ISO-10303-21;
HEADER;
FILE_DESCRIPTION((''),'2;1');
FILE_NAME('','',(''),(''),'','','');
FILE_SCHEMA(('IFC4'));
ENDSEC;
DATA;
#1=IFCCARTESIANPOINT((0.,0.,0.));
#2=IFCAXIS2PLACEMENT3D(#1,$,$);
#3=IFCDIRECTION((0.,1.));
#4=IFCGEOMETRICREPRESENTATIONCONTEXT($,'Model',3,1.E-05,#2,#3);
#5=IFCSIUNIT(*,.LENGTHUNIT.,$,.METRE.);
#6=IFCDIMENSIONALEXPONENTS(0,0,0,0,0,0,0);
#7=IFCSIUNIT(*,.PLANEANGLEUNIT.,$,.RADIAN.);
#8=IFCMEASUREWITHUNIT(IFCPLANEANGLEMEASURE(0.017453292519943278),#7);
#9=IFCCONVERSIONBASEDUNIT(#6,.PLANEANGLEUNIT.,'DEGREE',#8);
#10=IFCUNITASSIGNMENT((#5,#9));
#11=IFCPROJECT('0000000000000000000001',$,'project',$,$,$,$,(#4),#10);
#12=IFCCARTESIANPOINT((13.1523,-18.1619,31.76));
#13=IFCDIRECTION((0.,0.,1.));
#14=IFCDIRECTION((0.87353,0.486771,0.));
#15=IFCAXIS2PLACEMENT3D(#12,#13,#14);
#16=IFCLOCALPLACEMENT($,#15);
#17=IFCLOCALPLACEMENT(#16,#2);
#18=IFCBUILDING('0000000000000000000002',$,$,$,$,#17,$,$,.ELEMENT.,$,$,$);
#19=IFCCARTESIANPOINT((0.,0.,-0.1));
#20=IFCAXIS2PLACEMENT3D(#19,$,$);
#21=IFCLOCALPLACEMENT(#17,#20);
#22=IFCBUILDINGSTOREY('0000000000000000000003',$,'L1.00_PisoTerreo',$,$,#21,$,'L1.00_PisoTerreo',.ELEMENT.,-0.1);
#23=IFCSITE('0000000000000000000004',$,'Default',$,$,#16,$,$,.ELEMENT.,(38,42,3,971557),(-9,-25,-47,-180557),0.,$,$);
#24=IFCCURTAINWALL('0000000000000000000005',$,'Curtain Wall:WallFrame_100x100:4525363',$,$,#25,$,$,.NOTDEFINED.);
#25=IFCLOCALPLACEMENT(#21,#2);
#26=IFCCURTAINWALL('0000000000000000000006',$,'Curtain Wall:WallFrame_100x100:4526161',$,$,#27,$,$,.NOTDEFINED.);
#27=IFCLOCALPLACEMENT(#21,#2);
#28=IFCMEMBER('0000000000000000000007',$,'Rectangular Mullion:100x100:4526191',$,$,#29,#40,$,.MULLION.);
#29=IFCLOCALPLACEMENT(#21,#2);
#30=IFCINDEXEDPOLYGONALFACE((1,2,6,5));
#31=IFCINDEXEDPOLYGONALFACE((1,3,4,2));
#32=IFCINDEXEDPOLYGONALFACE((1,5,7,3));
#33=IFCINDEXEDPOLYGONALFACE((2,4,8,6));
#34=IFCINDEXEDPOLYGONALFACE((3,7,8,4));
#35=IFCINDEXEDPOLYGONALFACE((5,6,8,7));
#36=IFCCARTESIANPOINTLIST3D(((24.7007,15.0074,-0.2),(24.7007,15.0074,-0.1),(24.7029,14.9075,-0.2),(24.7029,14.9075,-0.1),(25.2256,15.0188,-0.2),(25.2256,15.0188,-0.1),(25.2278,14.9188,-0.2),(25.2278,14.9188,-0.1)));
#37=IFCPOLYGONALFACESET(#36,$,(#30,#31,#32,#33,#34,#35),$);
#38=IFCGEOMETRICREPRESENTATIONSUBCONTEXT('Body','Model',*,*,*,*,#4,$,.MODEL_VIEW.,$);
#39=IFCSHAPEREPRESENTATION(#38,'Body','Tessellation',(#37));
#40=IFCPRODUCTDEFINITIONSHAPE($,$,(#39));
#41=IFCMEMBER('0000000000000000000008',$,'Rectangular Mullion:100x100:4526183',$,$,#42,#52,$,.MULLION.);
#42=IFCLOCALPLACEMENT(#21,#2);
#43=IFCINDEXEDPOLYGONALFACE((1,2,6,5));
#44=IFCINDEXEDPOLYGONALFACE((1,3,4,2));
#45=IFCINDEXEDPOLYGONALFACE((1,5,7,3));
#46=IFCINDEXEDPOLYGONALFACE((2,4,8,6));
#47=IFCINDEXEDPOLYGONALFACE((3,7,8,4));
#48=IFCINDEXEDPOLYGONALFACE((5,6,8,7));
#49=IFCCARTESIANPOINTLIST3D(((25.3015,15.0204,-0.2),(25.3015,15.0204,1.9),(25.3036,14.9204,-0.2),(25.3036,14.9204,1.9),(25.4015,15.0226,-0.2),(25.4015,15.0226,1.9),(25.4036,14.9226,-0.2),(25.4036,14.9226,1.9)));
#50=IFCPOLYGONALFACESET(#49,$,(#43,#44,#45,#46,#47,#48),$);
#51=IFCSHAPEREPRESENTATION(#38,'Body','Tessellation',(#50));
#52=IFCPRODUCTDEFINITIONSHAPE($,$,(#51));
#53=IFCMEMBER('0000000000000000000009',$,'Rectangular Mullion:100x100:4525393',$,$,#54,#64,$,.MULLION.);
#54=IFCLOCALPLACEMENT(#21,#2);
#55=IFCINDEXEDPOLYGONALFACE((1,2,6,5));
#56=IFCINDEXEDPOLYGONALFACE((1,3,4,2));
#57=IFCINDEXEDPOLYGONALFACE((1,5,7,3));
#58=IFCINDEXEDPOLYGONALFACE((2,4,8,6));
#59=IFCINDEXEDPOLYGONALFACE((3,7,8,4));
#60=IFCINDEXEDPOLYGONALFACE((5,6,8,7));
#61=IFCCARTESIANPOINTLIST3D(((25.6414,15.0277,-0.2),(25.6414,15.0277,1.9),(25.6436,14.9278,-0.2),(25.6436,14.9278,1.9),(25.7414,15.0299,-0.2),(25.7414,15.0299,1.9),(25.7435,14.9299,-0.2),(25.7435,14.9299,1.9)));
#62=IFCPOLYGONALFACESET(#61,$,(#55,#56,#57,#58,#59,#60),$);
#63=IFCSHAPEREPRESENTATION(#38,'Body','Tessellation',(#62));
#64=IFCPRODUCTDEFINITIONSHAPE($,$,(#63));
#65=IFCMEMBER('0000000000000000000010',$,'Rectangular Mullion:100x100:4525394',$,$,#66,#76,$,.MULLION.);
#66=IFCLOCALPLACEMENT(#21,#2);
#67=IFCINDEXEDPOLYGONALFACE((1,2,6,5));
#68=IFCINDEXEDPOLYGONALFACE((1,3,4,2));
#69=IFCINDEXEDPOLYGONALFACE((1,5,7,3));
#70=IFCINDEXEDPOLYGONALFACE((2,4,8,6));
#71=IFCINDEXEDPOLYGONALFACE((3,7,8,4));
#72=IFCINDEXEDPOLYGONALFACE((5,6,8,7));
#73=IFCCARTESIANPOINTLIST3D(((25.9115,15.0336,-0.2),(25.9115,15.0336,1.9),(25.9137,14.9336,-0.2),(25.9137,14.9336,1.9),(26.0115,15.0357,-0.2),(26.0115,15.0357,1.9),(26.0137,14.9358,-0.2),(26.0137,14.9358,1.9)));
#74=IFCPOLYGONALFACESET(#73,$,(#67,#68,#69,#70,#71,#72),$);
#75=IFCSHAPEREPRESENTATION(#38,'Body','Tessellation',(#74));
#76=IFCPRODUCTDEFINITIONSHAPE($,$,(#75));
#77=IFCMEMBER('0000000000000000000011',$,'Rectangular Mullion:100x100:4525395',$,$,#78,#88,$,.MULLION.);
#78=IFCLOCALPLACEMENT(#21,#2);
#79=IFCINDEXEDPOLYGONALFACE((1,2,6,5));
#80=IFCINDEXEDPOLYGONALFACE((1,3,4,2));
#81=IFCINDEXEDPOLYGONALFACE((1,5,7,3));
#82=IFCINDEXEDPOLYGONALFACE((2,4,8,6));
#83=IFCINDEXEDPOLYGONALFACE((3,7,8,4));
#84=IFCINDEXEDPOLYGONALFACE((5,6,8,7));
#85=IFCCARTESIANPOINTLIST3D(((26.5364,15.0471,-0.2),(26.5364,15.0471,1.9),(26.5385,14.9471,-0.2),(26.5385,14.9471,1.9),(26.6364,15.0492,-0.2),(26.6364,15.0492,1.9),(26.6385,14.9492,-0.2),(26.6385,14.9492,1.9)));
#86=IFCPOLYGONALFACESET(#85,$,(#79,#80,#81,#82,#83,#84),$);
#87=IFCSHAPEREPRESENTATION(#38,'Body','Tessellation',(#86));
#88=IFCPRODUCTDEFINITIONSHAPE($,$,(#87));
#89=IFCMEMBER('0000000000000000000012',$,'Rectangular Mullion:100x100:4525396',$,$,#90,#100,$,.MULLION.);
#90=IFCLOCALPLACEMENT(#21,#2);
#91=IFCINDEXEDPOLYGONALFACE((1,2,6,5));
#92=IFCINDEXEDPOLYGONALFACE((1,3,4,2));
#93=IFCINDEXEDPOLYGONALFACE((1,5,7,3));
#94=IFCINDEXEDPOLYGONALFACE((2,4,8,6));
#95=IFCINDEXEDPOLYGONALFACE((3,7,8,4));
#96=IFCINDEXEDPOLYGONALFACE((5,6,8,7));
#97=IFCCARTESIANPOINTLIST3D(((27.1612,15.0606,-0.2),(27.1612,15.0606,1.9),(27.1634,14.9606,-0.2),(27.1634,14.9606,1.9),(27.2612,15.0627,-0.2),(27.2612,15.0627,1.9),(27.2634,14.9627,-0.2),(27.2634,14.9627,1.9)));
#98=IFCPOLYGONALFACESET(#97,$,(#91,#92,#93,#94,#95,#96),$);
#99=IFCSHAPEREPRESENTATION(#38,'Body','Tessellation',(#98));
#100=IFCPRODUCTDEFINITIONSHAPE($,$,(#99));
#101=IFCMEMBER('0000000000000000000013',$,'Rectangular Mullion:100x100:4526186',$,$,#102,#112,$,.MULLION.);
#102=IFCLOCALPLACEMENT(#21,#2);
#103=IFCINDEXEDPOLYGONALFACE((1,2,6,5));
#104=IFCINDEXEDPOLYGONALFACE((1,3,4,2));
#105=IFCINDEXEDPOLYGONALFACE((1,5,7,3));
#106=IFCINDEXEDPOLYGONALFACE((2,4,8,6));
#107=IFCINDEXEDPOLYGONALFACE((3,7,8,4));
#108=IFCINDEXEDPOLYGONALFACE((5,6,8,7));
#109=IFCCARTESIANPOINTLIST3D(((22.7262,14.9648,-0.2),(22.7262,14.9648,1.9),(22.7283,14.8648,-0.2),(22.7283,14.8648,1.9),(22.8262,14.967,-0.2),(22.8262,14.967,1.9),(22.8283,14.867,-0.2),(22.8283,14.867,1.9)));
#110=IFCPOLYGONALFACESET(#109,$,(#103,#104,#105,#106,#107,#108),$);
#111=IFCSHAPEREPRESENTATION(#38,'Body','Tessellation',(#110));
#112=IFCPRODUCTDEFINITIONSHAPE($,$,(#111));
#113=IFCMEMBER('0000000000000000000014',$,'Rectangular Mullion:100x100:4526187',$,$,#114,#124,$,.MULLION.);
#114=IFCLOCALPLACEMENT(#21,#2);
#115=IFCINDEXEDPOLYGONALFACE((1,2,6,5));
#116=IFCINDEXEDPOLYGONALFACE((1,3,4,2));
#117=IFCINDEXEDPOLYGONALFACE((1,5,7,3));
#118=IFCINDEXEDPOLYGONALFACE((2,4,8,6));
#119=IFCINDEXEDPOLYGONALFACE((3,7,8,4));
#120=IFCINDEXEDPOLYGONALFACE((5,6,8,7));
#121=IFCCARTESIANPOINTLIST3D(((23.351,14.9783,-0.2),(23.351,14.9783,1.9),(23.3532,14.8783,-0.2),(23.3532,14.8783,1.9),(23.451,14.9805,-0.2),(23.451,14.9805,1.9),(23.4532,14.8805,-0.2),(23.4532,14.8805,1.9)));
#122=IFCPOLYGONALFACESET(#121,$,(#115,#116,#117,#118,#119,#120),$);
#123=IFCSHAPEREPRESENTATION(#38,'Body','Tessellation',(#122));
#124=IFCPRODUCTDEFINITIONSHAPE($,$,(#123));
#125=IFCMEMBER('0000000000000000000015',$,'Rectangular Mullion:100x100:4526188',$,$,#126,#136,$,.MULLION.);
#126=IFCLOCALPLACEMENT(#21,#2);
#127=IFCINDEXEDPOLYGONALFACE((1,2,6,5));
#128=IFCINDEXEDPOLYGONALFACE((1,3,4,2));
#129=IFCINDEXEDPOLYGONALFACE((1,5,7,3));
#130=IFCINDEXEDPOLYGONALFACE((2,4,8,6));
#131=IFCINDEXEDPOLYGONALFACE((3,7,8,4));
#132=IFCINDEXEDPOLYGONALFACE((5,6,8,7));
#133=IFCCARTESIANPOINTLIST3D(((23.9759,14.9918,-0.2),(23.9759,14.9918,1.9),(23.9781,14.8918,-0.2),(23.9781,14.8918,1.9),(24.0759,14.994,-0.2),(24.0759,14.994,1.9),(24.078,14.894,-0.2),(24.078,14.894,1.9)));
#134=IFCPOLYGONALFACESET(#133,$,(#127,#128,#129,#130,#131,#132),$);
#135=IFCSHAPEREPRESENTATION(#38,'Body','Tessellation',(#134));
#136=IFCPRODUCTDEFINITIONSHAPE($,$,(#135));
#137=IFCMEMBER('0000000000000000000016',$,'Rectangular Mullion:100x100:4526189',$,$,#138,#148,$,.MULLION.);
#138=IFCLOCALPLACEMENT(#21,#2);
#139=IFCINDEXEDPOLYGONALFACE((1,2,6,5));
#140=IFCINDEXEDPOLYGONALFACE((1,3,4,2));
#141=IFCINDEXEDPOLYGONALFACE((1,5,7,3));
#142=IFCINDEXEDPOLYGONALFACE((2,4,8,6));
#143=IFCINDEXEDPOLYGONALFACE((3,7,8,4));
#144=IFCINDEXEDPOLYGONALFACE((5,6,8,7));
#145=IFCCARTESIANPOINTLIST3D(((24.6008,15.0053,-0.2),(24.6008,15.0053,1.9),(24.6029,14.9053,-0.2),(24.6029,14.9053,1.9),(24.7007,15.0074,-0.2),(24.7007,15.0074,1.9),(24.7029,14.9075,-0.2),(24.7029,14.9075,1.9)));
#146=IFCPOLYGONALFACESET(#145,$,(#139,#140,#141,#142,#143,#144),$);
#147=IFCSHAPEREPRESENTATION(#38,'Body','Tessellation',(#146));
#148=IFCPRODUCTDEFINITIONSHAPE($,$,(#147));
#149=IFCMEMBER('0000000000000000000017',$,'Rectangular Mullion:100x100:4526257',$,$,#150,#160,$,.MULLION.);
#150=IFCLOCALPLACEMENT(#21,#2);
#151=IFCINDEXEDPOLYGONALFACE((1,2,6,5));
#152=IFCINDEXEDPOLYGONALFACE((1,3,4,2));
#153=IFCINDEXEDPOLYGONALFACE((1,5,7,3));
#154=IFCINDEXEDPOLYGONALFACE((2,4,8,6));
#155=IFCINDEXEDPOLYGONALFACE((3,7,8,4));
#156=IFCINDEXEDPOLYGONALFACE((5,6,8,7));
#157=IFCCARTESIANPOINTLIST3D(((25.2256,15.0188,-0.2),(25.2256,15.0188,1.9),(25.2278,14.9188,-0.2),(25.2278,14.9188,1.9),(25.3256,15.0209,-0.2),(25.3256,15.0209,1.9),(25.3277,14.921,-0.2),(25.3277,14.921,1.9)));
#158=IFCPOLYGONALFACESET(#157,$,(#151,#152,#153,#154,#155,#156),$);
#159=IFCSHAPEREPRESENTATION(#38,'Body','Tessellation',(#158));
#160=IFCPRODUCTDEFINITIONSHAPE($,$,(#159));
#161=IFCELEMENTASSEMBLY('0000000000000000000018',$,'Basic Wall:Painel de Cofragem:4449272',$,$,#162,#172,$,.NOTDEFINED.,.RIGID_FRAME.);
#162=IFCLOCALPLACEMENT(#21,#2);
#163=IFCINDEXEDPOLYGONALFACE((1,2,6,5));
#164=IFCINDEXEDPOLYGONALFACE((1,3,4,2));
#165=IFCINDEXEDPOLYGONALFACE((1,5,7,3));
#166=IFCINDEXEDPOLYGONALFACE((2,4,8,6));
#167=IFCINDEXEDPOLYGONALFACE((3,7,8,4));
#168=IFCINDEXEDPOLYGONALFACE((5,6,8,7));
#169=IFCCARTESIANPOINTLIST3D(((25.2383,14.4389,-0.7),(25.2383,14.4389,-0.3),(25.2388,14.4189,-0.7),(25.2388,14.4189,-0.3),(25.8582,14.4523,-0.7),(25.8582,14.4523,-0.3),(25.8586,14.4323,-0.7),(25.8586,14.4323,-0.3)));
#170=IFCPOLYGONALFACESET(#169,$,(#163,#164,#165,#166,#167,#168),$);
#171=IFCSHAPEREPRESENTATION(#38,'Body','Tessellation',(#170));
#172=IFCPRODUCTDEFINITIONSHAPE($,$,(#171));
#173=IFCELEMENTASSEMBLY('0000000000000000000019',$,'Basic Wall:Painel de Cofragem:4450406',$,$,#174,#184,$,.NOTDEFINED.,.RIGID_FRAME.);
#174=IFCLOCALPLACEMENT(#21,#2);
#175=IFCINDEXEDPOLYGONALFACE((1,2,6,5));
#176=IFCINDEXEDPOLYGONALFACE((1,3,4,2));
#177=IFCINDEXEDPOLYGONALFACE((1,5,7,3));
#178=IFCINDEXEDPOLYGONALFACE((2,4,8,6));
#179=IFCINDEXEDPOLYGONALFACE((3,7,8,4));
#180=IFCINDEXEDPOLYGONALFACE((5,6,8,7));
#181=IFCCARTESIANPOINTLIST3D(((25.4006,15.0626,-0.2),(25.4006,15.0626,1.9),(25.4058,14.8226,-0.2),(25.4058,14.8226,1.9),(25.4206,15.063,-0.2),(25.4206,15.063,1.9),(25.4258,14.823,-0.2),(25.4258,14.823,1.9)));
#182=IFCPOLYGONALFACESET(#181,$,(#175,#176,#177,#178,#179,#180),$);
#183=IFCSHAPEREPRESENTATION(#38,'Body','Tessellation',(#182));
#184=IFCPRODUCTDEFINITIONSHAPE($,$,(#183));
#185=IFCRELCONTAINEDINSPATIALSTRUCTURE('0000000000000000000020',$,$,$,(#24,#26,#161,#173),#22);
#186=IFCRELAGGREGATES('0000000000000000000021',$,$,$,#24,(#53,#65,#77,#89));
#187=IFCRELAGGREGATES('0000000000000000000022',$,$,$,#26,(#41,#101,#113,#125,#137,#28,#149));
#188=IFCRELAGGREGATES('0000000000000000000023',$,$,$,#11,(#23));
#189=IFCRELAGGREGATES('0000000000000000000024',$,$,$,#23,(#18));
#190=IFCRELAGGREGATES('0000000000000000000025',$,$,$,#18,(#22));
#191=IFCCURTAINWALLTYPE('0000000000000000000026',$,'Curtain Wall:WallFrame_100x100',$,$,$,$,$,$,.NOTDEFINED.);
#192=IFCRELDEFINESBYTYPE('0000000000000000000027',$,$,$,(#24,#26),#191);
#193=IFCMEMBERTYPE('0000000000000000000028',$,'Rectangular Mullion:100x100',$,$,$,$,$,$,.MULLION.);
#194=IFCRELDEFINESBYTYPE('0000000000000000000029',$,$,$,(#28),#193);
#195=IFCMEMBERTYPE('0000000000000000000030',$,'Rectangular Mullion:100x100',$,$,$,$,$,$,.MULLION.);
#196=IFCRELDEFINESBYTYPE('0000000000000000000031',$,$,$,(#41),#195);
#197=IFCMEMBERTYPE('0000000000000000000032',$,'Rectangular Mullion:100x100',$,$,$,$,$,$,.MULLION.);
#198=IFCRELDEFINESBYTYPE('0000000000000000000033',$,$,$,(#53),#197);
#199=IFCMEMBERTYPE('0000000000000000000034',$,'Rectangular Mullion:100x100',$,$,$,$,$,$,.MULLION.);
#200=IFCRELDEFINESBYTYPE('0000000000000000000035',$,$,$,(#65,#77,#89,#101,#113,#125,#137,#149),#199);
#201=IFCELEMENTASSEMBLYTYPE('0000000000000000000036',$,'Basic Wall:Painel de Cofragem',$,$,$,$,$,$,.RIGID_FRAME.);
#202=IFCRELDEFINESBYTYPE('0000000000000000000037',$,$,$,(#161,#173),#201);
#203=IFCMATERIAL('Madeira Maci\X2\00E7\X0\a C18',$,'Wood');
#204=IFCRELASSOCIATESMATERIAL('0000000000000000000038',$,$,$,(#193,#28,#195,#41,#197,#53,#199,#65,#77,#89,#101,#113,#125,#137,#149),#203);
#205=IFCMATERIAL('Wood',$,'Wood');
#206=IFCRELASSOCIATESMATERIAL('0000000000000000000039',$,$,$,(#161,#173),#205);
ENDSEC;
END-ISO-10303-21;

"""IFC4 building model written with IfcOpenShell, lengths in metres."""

from ifc_helpers import new_model, entity, si_unit, converted_unit, direction, frame, origin, place, context, subcontext, project, spatial, indexed_curve, outline, extrude, source, transform, mapped, material, type_object, type_shapes, element, aggregate, save


model = new_model("IFC4")

# Units and contexts
model_context = context("Model", 3, precision=1e-05, world=origin(), true_north=direction((0.0, 1.0)))
body_context = subcontext(model_context, "Body", "Model", "MODEL_VIEW")
ifc_project = project(units=[si_unit("LENGTHUNIT", "METRE"), converted_unit("PLANEANGLEUNIT", "DEGREE", entity("IfcPlaneAngleMeasure", 0.017453292519943278), si_unit("PLANEANGLEUNIT", "RADIAN"), dimensions=[0, 0, 0, 0, 0, 0, 0])], contexts=[model_context])

# Site, building, storey
site_placement = place(None, frame((13.1523, -18.1619, 31.76), z_axis=(0.0, 0.0, 1.0), x_axis=(0.87353, 0.486771, 0.0)))
site = spatial("IfcSite", under=ifc_project, at=site_placement, Name="Default", CompositionType="ELEMENT", RefLatitude=(38, 42, 3, 971557), RefLongitude=(-9, -25, -47, -180557), RefElevation=0.0)
building_placement = place(site_placement, origin())
building = spatial("IfcBuilding", under=site, at=building_placement, CompositionType="ELEMENT")
storey_placement = place(building_placement, frame((0.0, 0.0, -0.1)))
storey = spatial("IfcBuildingStorey", under=building, at=storey_placement, Name="L1.00_PisoTerreo", LongName="L1.00_PisoTerreo", CompositionType="ELEMENT", Elevation=-0.1)

# Curtain walls
curtain_wall_type = type_object("IfcCurtainWallType", Name="Curtain Wall:WallFrame_100x100", PredefinedType="NOTDEFINED")
curtain_wall_1_placement = place(storey_placement, frame((0.0, 0.0, 0.1)))
curtain_wall_1 = element("IfcCurtainWall", 1, at=curtain_wall_1_placement, inside=storey, type_object=curtain_wall_type, Name="Curtain Wall:WallFrame_100x100:4525363", PredefinedType="NOTDEFINED")
ifc_material_1 = material(Name="Madeira Maciça C18", Category="Wood")
curtain_wall_2_placement = place(storey_placement, frame((0.0, 0.0, 0.1)))
curtain_wall_2 = element("IfcCurtainWall", 2, at=curtain_wall_2_placement, inside=storey, type_object=curtain_wall_type, Name="Curtain Wall:WallFrame_100x100:4526161", PredefinedType="NOTDEFINED")

# Members
member_type_1 = type_object("IfcMemberType", Name="Rectangular Mullion:100x100", PredefinedType="MULLION", material=ifc_material_1)
shared_shape_1 = source(origin(), body_context, "Body", "SweptSolid", [
    extrude(outline(indexed_curve([(-0.05, -0.05), (0.05, -0.05), (0.05, 0.05), (-0.05, 0.05), (-0.05, -0.05)], self_intersect=False)), frame((-0.05, 0.0, -0.525), z_axis=(0.0, 0.0, 1.0), x_axis=(0.0, -1.0, 0.0)), (0.0, 0.0, 1.0), 0.525),
])
type_shapes(member_type_1, [shared_shape_1])
member_1_placement = place(curtain_wall_2_placement, frame((24.7018, 14.9575, -0.3), z_axis=(-0.999767, -0.021581, 0.0), x_axis=(0.0, 0.0, -1.0)))
member_1 = element("IfcMember", 3, at=member_1_placement, type_object=member_type_1, material=ifc_material_1, Name="Rectangular Mullion:100x100:4526191", PredefinedType="MULLION", context=body_context, shape_type="MappedRepresentation", body=[
    mapped(shared_shape_1, transform((0.0, 0.0, 0.0), scale=1.0)),
])
member_type_2 = type_object("IfcMemberType", Name="Rectangular Mullion:100x100", PredefinedType="MULLION", material=ifc_material_1)
shared_shape_2 = source(origin(), body_context, "Body", "SweptSolid", [
    extrude(outline(indexed_curve([(-0.05, -0.05), (0.05, -0.05), (0.05, 0.05), (-0.05, 0.05), (-0.05, -0.05)], self_intersect=False)), frame((-0.05, 0.0, -2.1), z_axis=(0.0, 0.0, 1.0), x_axis=(-1.0, 0.0, 0.0)), (0.0, 0.0, 1.0), 2.1),
])
type_shapes(member_type_2, [shared_shape_2])
member_2_placement = place(curtain_wall_2_placement, frame((25.4025, 14.9726, -0.3), z_axis=(0.0, 0.0, -1.0), x_axis=(0.999767, 0.021581, 0.0)))
member_2 = element("IfcMember", 4, at=member_2_placement, type_object=member_type_2, material=ifc_material_1, Name="Rectangular Mullion:100x100:4526183", PredefinedType="MULLION", context=body_context, shape_type="MappedRepresentation", body=[
    mapped(shared_shape_2, transform((0.0, 0.0, 0.0), scale=1.0)),
])
member_type_3 = type_object("IfcMemberType", Name="Rectangular Mullion:100x100", PredefinedType="MULLION", material=ifc_material_1)
shared_shape_3 = source(origin(), body_context, "Body", "SweptSolid", [
    extrude(outline(indexed_curve([(-0.05, -0.05), (0.05, -0.05), (0.05, 0.05), (-0.05, 0.05), (-0.05, -0.05)], self_intersect=False)), frame((-0.05, 0.0, -2.1), z_axis=(0.0, 0.0, 1.0), x_axis=(0.0, -1.0, 0.0)), (0.0, 0.0, 1.0), 2.1),
])
type_shapes(member_type_3, [shared_shape_3])
member_3_placement = place(curtain_wall_1_placement, frame((25.6425, 14.9778, 1.8), z_axis=(0.0, 0.0, 1.0), x_axis=(-0.999767, -0.021581, 0.0)))
member_3 = element("IfcMember", 5, at=member_3_placement, type_object=member_type_3, material=ifc_material_1, Name="Rectangular Mullion:100x100:4525393", PredefinedType="MULLION", context=body_context, shape_type="MappedRepresentation", body=[
    mapped(shared_shape_3, transform((0.0, 0.0, 0.0), scale=1.0)),
])
member_type_4 = type_object("IfcMemberType", Name="Rectangular Mullion:100x100", PredefinedType="MULLION", material=ifc_material_1)
shared_shape_4 = source(origin(), body_context, "Body", "SweptSolid", [
    extrude(outline(indexed_curve([(-0.05, -0.05), (0.05, -0.05), (0.05, 0.05), (-0.05, 0.05), (-0.05, -0.05)], self_intersect=False)), frame((0.0, 0.0, -2.1), z_axis=(0.0, 0.0, 1.0), x_axis=(-1.0, 0.0, 0.0)), (0.0, 0.0, 1.0), 2.1),
])
type_shapes(member_type_4, [shared_shape_4])
member_4_placement = place(curtain_wall_1_placement, frame((25.9626, 14.9847, -0.3), z_axis=(0.0, 0.0, -1.0), x_axis=(0.999767, 0.021581, 0.0)))
member_4 = element("IfcMember", 6, at=member_4_placement, type_object=member_type_4, material=ifc_material_1, Name="Rectangular Mullion:100x100:4525394", PredefinedType="MULLION", context=body_context, shape_type="MappedRepresentation", body=[
    mapped(shared_shape_4, transform((0.0, 0.0, 0.0), scale=1.0)),
])
member_5_placement = place(curtain_wall_1_placement, frame((26.5874, 14.9982, -0.3), z_axis=(0.0, 0.0, -1.0), x_axis=(0.999767, 0.021581, 0.0)))
member_5 = element("IfcMember", 7, at=member_5_placement, type_object=member_type_4, material=ifc_material_1, Name="Rectangular Mullion:100x100:4525395", PredefinedType="MULLION", context=body_context, shape_type="MappedRepresentation", body=[
    mapped(shared_shape_4, transform((0.0, 0.0, 0.0), scale=1.0)),
])
member_6_placement = place(curtain_wall_1_placement, frame((27.2123, 15.0116, -0.3), z_axis=(0.0, 0.0, -1.0), x_axis=(0.999767, 0.021581, 0.0)))
member_6 = element("IfcMember", 8, at=member_6_placement, type_object=member_type_4, material=ifc_material_1, Name="Rectangular Mullion:100x100:4525396", PredefinedType="MULLION", context=body_context, shape_type="MappedRepresentation", body=[
    mapped(shared_shape_4, transform((0.0, 0.0, 0.0), scale=1.0)),
])
aggregate(curtain_wall_1, [member_3, member_4, member_5, member_6])
member_7_placement = place(curtain_wall_2_placement, frame((22.7773, 14.9159, -0.3), z_axis=(0.0, 0.0, -1.0), x_axis=(0.999767, 0.021581, 0.0)))
member_7 = element("IfcMember", 9, at=member_7_placement, type_object=member_type_4, material=ifc_material_1, Name="Rectangular Mullion:100x100:4526186", PredefinedType="MULLION", context=body_context, shape_type="MappedRepresentation", body=[
    mapped(shared_shape_4, transform((0.0, 0.0, 0.0), scale=1.0)),
])
member_8_placement = place(curtain_wall_2_placement, frame((23.4021, 14.9294, -0.3), z_axis=(0.0, 0.0, -1.0), x_axis=(0.999767, 0.021581, 0.0)))
member_8 = element("IfcMember", 10, at=member_8_placement, type_object=member_type_4, material=ifc_material_1, Name="Rectangular Mullion:100x100:4526187", PredefinedType="MULLION", context=body_context, shape_type="MappedRepresentation", body=[
    mapped(shared_shape_4, transform((0.0, 0.0, 0.0), scale=1.0)),
])
member_9_placement = place(curtain_wall_2_placement, frame((24.027, 14.9429, -0.3), z_axis=(0.0, 0.0, -1.0), x_axis=(0.999767, 0.021581, 0.0)))
member_9 = element("IfcMember", 11, at=member_9_placement, type_object=member_type_4, material=ifc_material_1, Name="Rectangular Mullion:100x100:4526188", PredefinedType="MULLION", context=body_context, shape_type="MappedRepresentation", body=[
    mapped(shared_shape_4, transform((0.0, 0.0, 0.0), scale=1.0)),
])
member_10_placement = place(curtain_wall_2_placement, frame((24.6518, 14.9564, -0.3), z_axis=(0.0, 0.0, -1.0), x_axis=(0.999767, 0.021581, 0.0)))
member_10 = element("IfcMember", 12, at=member_10_placement, type_object=member_type_4, material=ifc_material_1, Name="Rectangular Mullion:100x100:4526189", PredefinedType="MULLION", context=body_context, shape_type="MappedRepresentation", body=[
    mapped(shared_shape_4, transform((0.0, 0.0, 0.0), scale=1.0)),
])
member_11_placement = place(curtain_wall_2_placement, frame((25.2767, 14.9699, -0.3), z_axis=(0.0, 0.0, -1.0), x_axis=(0.999767, 0.021581, 0.0)))
member_11 = element("IfcMember", 13, at=member_11_placement, type_object=member_type_4, material=ifc_material_1, Name="Rectangular Mullion:100x100:4526257", PredefinedType="MULLION", context=body_context, shape_type="MappedRepresentation", body=[
    mapped(shared_shape_4, transform((0.0, 0.0, 0.0), scale=1.0)),
])
aggregate(curtain_wall_2, [member_2, member_7, member_8, member_9, member_10, member_1, member_11])

# Element assemblies
ifc_material_2 = material(Name="Wood", Category="Wood")
element_assembly_type = type_object("IfcElementAssemblyType", Name="Basic Wall:Painel de Cofragem", PredefinedType="RIGID_FRAME")
assembly_1_placement = place(storey_placement, frame((25.2385, 14.4289, -0.7), z_axis=(0.0, 0.0, 1.0), x_axis=(0.999767, 0.021581, 0.0)))
element("IfcElementAssembly", 14, at=assembly_1_placement, inside=storey, type_object=element_assembly_type, material=ifc_material_2, Name="Basic Wall:Painel de Cofragem:4449272", AssemblyPlace="NOTDEFINED", PredefinedType="RIGID_FRAME", context=body_context, shape_type="SweptSolid", body=[
    extrude(outline(indexed_curve([(0.62, 0.01), (0.0, 0.01), (0.0, -0.01), (0.62, -0.01), (0.62, 0.01)], self_intersect=False)), origin(), (0.0, 0.0, 1.0), 0.4),
])
assembly_2_placement = place(storey_placement, frame((25.4106, 15.0628, -0.2), z_axis=(0.0, 0.0, 1.0), x_axis=(0.021581, -0.999767, 0.0)))
element("IfcElementAssembly", 15, at=assembly_2_placement, inside=storey, type_object=element_assembly_type, material=ifc_material_2, Name="Basic Wall:Painel de Cofragem:4450406", AssemblyPlace="NOTDEFINED", PredefinedType="RIGID_FRAME", context=body_context, shape_type="SweptSolid", body=[
    extrude(outline(indexed_curve([(0.24, 0.01), (0.0, 0.01), (0.0, -0.01), (0.24, -0.01), (0.24, 0.01)], self_intersect=False)), origin(), (0.0, 0.0, 1.0), 2.1),
])

save(model, "model.ifc")
